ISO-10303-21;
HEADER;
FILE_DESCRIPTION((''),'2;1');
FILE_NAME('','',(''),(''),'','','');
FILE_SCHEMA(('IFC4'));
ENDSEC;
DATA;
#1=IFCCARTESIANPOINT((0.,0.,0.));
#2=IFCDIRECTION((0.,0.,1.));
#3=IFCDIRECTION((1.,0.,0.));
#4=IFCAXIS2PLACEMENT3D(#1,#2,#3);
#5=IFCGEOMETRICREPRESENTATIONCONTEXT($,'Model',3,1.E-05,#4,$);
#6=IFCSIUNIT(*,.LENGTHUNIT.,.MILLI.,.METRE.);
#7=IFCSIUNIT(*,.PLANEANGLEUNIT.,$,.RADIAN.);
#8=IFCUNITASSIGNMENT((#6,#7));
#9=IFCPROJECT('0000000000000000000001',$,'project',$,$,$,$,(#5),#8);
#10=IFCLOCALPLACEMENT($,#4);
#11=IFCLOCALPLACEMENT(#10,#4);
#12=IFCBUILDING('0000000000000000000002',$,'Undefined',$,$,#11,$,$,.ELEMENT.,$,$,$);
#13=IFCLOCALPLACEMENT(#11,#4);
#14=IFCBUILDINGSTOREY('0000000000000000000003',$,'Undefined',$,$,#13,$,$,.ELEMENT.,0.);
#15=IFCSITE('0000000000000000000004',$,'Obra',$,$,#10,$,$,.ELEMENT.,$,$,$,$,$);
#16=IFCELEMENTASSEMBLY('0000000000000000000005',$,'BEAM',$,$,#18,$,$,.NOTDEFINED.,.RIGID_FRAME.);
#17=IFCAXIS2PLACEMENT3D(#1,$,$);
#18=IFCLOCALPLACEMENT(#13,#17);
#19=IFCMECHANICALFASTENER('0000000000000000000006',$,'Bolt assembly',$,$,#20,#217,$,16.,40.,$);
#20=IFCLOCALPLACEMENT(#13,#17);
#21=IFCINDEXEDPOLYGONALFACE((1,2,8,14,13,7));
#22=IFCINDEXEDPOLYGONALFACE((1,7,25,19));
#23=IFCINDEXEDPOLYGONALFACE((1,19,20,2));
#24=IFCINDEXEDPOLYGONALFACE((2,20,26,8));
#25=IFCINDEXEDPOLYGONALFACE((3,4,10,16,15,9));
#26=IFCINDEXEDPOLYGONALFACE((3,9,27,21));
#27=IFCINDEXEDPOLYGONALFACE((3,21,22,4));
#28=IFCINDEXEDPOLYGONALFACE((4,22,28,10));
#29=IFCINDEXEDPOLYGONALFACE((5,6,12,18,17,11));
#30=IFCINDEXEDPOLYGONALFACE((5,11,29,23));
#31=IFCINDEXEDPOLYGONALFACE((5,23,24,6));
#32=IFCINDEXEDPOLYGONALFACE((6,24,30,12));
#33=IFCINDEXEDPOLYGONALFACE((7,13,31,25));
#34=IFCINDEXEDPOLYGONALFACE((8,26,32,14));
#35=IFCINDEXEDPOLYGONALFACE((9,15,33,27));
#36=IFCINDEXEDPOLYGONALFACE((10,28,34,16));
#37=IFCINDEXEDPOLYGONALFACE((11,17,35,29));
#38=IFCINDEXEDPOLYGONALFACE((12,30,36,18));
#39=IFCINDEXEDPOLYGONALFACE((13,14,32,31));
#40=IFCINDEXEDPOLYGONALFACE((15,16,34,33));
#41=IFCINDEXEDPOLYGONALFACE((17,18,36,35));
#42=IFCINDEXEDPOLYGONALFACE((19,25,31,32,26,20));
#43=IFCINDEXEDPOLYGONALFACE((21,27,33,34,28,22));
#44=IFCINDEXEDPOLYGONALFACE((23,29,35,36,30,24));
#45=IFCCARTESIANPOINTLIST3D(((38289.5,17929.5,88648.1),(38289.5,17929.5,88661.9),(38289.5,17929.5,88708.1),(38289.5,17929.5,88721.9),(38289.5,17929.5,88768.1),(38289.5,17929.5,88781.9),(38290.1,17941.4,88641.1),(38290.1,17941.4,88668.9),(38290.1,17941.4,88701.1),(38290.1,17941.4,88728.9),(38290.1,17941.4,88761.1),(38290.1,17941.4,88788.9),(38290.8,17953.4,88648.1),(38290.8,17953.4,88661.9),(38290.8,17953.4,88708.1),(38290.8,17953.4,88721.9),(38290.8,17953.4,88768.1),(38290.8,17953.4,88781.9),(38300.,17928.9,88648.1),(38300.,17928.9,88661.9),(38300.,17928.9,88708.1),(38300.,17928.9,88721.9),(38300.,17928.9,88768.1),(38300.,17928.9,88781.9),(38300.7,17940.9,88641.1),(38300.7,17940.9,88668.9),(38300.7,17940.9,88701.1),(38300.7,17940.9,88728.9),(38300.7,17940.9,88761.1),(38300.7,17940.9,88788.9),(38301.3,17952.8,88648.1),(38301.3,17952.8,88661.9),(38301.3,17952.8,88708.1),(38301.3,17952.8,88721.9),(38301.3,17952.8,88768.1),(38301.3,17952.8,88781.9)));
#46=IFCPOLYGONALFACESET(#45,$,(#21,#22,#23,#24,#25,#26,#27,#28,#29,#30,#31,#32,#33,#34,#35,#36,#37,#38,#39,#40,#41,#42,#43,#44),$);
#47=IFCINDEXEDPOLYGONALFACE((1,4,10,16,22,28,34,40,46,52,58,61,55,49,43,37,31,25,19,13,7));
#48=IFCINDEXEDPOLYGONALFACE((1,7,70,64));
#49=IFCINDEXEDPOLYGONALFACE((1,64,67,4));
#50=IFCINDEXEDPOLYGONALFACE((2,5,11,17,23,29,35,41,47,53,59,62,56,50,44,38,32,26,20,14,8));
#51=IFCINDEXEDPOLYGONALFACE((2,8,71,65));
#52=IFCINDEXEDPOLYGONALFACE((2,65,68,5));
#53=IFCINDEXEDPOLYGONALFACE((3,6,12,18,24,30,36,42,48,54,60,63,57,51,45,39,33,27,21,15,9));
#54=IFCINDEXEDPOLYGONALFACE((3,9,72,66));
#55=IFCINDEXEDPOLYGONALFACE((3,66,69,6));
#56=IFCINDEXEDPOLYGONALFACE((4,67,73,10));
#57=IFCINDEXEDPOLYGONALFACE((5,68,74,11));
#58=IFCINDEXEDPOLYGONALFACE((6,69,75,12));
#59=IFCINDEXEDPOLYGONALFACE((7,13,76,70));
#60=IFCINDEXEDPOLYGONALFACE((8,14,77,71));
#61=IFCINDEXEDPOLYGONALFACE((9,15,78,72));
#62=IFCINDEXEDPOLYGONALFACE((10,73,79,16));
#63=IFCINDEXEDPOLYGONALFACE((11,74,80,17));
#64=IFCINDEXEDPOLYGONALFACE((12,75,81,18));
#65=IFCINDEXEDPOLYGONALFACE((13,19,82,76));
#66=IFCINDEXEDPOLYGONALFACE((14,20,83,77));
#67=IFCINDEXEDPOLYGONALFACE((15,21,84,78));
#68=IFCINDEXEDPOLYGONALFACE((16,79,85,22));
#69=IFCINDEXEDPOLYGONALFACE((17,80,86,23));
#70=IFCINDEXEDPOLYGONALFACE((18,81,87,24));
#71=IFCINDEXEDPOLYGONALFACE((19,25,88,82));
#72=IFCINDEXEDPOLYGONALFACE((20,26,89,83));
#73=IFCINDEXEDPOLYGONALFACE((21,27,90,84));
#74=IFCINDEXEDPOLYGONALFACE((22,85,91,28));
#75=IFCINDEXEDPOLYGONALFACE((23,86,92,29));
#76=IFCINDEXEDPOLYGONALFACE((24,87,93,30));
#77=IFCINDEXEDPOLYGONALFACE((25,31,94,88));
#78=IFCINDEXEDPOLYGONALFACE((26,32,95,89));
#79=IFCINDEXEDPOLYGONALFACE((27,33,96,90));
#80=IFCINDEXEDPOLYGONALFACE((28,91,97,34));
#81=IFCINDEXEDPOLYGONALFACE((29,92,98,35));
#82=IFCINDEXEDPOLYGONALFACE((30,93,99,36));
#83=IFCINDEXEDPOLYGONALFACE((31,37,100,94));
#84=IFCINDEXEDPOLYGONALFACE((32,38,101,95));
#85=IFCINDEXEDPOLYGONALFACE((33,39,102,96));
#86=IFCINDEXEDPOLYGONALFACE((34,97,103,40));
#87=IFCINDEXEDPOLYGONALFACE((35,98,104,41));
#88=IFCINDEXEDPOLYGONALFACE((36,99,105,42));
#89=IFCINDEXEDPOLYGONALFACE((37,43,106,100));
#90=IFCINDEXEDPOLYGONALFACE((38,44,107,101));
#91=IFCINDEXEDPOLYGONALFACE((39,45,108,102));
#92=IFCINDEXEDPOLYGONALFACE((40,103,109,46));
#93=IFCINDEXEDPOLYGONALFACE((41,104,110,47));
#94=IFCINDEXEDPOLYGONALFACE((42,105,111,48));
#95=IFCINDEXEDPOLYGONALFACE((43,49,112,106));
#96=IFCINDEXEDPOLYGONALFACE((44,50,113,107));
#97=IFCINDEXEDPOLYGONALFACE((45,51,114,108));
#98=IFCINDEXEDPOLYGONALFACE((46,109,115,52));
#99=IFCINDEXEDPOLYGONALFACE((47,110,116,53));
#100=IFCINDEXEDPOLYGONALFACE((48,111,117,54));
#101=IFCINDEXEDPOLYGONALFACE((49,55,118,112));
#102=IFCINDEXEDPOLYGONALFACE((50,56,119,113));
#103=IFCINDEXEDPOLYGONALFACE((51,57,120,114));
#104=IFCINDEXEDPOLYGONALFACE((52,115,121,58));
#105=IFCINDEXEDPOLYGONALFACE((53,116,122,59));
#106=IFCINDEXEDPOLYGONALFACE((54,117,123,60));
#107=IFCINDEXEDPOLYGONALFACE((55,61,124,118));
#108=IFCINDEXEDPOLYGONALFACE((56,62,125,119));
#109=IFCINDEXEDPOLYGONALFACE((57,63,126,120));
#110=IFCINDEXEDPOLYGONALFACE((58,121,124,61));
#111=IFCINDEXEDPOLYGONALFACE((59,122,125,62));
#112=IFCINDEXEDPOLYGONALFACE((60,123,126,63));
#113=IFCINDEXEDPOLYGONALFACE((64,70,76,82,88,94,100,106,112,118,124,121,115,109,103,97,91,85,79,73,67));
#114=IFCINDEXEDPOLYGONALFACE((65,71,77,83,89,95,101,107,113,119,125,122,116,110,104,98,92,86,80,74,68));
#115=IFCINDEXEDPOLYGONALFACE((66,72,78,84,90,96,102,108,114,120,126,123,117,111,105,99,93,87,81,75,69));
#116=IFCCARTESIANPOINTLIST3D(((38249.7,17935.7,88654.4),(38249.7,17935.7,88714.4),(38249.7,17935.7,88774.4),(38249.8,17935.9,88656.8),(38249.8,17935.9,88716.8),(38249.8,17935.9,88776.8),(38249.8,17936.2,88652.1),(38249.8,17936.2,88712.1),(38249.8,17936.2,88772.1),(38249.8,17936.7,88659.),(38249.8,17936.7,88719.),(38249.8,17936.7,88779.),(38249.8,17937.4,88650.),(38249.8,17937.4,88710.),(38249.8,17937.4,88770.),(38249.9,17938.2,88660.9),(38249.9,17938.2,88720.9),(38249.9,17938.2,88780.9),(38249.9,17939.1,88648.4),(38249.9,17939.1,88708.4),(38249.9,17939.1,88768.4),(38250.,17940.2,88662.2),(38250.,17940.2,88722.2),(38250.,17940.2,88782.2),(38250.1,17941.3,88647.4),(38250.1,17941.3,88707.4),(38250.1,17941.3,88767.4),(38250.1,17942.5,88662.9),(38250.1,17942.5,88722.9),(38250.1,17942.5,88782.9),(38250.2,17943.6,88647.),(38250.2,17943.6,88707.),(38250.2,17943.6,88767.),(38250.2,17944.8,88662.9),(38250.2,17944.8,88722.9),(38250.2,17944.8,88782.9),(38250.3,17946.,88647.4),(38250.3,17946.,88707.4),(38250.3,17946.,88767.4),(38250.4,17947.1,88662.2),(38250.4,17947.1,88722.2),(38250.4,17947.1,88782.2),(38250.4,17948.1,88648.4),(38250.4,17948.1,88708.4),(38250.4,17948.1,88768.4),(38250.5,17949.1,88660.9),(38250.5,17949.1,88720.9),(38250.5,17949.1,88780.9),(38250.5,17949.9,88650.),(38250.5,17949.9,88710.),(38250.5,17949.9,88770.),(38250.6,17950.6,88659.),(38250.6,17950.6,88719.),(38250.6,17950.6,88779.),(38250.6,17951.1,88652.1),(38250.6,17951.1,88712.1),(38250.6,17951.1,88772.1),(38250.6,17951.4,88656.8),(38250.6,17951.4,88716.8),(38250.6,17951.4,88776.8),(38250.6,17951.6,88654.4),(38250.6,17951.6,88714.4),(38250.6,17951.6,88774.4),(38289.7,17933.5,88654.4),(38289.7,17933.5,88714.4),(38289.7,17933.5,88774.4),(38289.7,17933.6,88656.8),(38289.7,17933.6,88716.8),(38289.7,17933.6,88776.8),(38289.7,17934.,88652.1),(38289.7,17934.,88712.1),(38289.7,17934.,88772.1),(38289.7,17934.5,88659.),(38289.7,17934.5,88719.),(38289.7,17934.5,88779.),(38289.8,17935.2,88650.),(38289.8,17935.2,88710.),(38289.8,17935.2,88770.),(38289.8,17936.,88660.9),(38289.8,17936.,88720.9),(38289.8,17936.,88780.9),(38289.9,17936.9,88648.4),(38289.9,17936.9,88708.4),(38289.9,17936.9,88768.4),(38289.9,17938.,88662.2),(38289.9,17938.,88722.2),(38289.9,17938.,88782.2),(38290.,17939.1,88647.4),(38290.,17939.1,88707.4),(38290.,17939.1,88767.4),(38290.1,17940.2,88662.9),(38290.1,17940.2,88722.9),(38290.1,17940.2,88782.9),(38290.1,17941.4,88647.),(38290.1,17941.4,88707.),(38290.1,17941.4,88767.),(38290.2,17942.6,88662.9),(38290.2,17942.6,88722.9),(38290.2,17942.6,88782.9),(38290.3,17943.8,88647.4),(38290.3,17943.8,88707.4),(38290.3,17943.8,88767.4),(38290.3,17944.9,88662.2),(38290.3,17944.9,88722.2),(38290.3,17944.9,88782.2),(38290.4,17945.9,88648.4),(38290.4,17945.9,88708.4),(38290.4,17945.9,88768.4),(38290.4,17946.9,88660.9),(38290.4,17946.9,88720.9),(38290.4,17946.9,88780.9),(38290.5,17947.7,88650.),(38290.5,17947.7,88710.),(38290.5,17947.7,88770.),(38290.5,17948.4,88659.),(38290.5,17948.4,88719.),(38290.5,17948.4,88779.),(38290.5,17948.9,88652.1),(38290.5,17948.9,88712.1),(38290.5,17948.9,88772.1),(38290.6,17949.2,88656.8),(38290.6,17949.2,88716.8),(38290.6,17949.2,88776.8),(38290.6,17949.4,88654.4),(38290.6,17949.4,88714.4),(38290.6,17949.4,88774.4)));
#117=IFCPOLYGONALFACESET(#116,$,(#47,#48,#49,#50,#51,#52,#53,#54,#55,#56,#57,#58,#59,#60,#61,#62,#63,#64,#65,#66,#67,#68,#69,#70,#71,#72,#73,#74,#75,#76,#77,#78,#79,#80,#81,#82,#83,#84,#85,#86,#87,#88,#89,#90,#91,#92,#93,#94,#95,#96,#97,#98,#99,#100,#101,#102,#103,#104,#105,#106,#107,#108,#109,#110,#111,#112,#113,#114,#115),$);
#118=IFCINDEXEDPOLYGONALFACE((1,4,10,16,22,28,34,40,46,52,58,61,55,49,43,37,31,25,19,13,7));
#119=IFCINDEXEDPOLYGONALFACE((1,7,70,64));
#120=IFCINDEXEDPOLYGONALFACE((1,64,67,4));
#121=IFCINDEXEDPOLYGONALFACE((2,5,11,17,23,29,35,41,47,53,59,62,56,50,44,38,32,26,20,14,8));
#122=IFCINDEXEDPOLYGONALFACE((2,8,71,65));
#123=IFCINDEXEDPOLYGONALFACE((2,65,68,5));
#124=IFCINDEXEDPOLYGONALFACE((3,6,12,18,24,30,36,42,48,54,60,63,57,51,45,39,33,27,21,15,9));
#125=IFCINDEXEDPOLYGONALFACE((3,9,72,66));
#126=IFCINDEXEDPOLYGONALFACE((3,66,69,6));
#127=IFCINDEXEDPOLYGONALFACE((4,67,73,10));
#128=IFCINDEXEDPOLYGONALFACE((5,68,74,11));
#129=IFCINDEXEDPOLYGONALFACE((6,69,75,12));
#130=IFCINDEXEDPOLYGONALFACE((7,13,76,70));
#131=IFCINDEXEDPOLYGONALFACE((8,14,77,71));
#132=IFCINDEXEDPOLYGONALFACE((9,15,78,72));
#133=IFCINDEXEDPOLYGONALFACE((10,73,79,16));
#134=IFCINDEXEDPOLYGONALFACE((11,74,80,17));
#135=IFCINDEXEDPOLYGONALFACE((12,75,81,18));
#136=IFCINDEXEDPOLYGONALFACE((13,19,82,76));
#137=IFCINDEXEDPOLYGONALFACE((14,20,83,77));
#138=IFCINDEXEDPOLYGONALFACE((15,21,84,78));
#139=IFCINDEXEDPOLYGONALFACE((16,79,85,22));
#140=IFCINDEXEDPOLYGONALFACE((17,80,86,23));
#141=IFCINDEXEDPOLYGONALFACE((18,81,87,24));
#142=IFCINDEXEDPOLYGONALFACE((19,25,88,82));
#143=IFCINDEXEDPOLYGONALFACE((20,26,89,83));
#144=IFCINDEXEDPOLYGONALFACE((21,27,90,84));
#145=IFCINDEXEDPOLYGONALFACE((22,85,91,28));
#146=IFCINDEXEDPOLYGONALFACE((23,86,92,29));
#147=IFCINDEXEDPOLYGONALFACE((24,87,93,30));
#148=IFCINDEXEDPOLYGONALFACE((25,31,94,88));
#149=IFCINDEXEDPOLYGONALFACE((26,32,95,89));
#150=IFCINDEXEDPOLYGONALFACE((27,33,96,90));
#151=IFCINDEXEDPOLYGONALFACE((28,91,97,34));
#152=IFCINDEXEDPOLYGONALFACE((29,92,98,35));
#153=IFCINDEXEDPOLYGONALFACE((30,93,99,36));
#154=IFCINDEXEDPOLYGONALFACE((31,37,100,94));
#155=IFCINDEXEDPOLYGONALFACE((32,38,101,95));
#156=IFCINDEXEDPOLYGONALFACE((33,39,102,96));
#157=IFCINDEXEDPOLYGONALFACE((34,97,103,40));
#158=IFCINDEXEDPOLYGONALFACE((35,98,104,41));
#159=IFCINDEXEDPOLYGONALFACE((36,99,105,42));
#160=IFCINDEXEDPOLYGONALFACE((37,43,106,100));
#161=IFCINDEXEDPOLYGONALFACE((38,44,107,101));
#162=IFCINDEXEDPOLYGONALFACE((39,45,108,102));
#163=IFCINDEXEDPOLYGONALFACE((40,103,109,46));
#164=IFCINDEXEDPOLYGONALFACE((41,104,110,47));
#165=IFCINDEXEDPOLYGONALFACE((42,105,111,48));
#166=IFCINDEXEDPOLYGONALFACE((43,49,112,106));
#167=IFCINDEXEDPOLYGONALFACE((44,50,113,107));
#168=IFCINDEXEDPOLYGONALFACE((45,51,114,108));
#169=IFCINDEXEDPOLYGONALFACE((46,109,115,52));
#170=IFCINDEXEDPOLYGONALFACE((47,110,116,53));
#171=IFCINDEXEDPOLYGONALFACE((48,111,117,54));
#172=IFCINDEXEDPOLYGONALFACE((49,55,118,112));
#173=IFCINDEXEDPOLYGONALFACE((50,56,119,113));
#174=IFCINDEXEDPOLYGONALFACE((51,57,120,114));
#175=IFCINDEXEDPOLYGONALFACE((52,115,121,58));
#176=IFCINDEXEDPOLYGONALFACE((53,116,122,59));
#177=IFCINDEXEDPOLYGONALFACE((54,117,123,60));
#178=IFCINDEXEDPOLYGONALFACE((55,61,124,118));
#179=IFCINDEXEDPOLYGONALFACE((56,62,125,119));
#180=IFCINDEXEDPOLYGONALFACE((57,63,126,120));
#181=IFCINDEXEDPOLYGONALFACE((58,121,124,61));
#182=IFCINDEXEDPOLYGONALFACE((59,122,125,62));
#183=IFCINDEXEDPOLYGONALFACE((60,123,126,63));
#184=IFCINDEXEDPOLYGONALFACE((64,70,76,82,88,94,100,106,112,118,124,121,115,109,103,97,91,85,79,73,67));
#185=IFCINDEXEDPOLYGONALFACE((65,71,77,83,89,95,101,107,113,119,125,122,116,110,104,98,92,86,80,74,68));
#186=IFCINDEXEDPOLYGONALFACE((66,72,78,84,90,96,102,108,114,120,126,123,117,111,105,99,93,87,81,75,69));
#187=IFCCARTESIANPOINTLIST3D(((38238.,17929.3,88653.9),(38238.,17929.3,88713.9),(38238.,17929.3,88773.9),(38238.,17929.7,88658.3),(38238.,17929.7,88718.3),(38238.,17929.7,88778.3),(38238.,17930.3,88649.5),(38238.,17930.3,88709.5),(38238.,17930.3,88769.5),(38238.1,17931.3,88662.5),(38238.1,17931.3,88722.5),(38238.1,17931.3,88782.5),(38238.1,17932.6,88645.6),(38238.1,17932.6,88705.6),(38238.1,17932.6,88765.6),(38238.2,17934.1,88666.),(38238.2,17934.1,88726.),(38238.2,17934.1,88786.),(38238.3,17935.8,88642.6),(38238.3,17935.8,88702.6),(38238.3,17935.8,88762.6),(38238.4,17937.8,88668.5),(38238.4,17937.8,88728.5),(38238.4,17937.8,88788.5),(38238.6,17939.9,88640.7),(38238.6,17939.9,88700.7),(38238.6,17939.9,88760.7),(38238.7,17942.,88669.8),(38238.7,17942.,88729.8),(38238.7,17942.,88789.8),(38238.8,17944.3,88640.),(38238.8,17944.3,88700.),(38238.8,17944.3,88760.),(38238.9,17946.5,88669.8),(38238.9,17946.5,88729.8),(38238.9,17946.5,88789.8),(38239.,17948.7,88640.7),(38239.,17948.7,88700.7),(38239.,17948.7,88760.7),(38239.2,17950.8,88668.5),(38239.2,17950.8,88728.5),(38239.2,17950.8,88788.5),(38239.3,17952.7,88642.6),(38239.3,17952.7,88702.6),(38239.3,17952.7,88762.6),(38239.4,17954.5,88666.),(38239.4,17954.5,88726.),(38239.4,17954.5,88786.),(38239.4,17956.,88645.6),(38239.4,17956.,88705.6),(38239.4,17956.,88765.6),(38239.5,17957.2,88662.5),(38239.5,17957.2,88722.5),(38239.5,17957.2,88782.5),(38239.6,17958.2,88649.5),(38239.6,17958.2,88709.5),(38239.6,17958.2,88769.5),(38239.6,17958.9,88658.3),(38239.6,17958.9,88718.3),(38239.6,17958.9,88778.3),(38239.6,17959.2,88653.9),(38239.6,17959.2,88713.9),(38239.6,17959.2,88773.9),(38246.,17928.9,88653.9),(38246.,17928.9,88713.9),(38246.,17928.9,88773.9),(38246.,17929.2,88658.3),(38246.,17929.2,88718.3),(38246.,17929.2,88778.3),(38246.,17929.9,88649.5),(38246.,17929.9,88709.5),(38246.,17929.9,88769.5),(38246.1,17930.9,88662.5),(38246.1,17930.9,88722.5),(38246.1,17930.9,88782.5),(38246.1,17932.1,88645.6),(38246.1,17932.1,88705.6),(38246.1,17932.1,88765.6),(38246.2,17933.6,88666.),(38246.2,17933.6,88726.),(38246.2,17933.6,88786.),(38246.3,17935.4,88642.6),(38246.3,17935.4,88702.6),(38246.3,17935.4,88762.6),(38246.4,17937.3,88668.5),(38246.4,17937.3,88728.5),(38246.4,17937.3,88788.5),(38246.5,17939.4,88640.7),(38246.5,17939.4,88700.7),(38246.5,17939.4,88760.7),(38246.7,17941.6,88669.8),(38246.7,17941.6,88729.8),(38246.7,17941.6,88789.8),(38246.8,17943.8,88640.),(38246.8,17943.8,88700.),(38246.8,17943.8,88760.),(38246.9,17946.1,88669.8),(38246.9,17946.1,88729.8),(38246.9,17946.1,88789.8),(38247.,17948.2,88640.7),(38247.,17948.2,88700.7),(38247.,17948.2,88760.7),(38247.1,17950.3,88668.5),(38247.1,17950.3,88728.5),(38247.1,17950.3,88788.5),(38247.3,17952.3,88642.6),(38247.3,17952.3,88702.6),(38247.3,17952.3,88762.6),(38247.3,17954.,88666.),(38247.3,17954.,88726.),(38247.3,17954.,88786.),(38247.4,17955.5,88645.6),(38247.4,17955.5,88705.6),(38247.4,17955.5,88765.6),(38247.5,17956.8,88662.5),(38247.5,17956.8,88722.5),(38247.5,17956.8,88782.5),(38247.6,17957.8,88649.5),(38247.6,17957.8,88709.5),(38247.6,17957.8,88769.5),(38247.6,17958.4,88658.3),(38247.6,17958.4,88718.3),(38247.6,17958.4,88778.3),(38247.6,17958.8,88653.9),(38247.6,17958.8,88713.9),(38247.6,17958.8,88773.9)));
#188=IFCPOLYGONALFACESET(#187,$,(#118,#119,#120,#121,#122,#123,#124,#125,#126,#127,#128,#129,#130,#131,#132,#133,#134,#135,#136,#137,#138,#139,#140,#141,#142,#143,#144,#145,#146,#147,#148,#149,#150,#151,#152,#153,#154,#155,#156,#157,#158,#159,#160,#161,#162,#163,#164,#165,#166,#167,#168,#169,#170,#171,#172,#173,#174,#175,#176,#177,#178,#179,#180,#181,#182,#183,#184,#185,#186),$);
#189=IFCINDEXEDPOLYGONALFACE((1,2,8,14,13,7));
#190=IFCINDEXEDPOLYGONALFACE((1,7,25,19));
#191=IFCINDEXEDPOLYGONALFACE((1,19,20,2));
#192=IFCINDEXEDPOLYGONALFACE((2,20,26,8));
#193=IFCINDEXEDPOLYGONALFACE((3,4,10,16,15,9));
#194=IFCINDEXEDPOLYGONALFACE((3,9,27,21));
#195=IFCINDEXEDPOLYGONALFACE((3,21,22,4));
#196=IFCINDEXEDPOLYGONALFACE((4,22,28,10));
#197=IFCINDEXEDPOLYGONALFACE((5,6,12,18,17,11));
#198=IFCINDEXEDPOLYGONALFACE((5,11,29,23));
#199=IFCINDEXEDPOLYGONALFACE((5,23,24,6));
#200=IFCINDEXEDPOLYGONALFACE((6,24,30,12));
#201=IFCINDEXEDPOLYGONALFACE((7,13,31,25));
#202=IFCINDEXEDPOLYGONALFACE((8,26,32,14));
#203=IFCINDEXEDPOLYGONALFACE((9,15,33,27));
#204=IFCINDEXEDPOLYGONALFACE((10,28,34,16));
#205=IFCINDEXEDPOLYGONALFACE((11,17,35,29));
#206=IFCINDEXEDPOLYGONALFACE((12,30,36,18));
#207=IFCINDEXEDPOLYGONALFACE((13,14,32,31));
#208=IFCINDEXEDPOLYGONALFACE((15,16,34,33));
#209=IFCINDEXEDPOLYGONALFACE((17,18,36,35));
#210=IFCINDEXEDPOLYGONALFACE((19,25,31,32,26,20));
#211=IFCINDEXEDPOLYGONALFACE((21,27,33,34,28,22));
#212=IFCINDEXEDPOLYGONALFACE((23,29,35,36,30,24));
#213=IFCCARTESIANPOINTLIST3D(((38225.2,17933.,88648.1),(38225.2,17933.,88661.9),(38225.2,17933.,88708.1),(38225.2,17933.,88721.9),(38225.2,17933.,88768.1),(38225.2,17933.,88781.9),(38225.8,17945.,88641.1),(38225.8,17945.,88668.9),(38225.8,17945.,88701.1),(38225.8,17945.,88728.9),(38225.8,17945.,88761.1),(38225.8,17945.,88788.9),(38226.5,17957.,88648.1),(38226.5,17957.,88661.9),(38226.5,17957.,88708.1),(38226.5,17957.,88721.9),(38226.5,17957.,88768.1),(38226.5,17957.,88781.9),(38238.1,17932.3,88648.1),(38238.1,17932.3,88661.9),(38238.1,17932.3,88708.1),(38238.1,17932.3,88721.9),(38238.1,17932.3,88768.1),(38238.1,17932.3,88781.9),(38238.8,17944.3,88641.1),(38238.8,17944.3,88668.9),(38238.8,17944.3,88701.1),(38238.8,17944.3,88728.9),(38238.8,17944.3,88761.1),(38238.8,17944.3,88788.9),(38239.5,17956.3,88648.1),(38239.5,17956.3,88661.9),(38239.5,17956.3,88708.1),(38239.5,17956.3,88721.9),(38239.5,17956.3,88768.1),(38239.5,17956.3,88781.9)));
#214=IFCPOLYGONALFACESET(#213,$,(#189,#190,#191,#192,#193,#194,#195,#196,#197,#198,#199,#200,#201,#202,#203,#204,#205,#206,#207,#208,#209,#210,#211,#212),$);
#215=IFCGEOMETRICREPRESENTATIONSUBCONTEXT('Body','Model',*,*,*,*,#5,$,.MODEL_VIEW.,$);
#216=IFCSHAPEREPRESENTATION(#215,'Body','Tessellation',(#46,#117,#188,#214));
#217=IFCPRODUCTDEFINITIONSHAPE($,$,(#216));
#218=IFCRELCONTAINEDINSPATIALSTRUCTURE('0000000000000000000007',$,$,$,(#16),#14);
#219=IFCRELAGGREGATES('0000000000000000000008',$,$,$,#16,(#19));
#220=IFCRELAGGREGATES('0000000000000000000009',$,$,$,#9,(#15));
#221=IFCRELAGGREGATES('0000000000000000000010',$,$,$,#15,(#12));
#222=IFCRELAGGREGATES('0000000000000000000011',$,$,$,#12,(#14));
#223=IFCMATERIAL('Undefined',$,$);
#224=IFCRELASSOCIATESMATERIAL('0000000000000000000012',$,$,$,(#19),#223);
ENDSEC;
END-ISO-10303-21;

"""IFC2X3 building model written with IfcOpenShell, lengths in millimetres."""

from ifc_helpers import new_model, si_unit, frame, origin_with_axes, origin_2d_with_axis, place, context, subcontext, project, spatial, polyline, circle, outline, extrude, source, transform, mapped, material, element, aggregate, save


model = new_model("IFC2X3")

# Units and contexts
model_context = context("Model", 3, precision=1e-05, world=origin_with_axes())
body_context = subcontext(model_context, "Body", "Model", "MODEL_VIEW")
ifc_project = project(units=[si_unit("LENGTHUNIT", "METRE", prefix="MILLI"), si_unit("PLANEANGLEUNIT", "RADIAN")], contexts=[model_context])

# Site, building, storey
site_placement = place(None, origin_with_axes())
site = spatial("IfcSite", under=ifc_project, at=site_placement, Name="Obra", CompositionType="ELEMENT")
building_placement = place(site_placement, origin_with_axes())
building = spatial("IfcBuilding", under=site, at=building_placement, Name="Undefined", CompositionType="ELEMENT")
storey_placement = place(building_placement, origin_with_axes())
storey = spatial("IfcBuildingStorey", under=building, at=storey_placement, Name="Undefined", CompositionType="ELEMENT", Elevation=0.0)

# Element assembly, mechanical fastener
ifc_material_1 = material(Name="Undefined")
shared_shape_1 = source(origin_with_axes(), body_context, "Body", "SweptSolid", [
    extrude(outline(polyline([(13.9, 0.0), (6.9, 12.0), (-6.9, 12.0), (-13.9, 0.0), (-6.9, -12.0), (6.9, -12.0), (13.9, 0.0)])), frame((0.0, -19.7, 0.0), z_axis=(0.0, 1.0, 0.0), x_axis=(1.0, 0.0, 0.0)), (0.0, 0.0, 1.0), 10.6),
    extrude(circle(Radius=8.0, at=origin_2d_with_axis()), frame((0.0, -9.1, 0.0), z_axis=(0.0, 1.0, 0.0), x_axis=(1.0, 0.0, 0.0)), (0.0, 0.0, 1.0), 40.0),
    extrude(circle(Radius=15.0, at=origin_2d_with_axis()), frame((0.0, 34.3, 0.0), z_axis=(0.0, 1.0, 0.0), x_axis=(1.0, 0.0, 0.0)), (0.0, 0.0, 1.0), 8.0),
    extrude(outline(polyline([(13.9, 0.0), (6.9, 12.0), (-6.9, 12.0), (-13.9, 0.0), (-6.9, -12.0), (6.9, -12.0), (13.9, 0.0)])), frame((0.0, 42.3, 0.0), z_axis=(0.0, 1.0, 0.0), x_axis=(1.0, 0.0, 0.0)), (0.0, 0.0, 1.0), 13.0),
])
assembly_1_placement = place(storey_placement, origin_with_axes())
assembly_1 = element("IfcElementAssembly", 1, at=assembly_1_placement, inside=storey, Name="BEAM", AssemblyPlace="NOTDEFINED", PredefinedType="RIGID_FRAME")
mechanical_fastener_1_placement = place(assembly_1_placement, frame((38278.3, 17892.0, 88835.0), z_axis=(0.055268, 0.998472, 0.0), x_axis=(0.0, 0.0, -1.0)))
mechanical_fastener_1 = element("IfcMechanicalFastener", 2, at=mechanical_fastener_1_placement, material=ifc_material_1, Name="Bolt assembly", NominalDiameter=16.0, NominalLength=40.0, context=body_context, shape_type="MappedRepresentation", body=[
    mapped(shared_shape_1, transform((60.0, 0.0, 50.0))),
    mapped(shared_shape_1, transform((120.0, 0.0, 50.0))),
    mapped(shared_shape_1, transform((180.0, 0.0, 50.0))),
])
aggregate(assembly_1, [mechanical_fastener_1])

save(model, "model.ifc")
